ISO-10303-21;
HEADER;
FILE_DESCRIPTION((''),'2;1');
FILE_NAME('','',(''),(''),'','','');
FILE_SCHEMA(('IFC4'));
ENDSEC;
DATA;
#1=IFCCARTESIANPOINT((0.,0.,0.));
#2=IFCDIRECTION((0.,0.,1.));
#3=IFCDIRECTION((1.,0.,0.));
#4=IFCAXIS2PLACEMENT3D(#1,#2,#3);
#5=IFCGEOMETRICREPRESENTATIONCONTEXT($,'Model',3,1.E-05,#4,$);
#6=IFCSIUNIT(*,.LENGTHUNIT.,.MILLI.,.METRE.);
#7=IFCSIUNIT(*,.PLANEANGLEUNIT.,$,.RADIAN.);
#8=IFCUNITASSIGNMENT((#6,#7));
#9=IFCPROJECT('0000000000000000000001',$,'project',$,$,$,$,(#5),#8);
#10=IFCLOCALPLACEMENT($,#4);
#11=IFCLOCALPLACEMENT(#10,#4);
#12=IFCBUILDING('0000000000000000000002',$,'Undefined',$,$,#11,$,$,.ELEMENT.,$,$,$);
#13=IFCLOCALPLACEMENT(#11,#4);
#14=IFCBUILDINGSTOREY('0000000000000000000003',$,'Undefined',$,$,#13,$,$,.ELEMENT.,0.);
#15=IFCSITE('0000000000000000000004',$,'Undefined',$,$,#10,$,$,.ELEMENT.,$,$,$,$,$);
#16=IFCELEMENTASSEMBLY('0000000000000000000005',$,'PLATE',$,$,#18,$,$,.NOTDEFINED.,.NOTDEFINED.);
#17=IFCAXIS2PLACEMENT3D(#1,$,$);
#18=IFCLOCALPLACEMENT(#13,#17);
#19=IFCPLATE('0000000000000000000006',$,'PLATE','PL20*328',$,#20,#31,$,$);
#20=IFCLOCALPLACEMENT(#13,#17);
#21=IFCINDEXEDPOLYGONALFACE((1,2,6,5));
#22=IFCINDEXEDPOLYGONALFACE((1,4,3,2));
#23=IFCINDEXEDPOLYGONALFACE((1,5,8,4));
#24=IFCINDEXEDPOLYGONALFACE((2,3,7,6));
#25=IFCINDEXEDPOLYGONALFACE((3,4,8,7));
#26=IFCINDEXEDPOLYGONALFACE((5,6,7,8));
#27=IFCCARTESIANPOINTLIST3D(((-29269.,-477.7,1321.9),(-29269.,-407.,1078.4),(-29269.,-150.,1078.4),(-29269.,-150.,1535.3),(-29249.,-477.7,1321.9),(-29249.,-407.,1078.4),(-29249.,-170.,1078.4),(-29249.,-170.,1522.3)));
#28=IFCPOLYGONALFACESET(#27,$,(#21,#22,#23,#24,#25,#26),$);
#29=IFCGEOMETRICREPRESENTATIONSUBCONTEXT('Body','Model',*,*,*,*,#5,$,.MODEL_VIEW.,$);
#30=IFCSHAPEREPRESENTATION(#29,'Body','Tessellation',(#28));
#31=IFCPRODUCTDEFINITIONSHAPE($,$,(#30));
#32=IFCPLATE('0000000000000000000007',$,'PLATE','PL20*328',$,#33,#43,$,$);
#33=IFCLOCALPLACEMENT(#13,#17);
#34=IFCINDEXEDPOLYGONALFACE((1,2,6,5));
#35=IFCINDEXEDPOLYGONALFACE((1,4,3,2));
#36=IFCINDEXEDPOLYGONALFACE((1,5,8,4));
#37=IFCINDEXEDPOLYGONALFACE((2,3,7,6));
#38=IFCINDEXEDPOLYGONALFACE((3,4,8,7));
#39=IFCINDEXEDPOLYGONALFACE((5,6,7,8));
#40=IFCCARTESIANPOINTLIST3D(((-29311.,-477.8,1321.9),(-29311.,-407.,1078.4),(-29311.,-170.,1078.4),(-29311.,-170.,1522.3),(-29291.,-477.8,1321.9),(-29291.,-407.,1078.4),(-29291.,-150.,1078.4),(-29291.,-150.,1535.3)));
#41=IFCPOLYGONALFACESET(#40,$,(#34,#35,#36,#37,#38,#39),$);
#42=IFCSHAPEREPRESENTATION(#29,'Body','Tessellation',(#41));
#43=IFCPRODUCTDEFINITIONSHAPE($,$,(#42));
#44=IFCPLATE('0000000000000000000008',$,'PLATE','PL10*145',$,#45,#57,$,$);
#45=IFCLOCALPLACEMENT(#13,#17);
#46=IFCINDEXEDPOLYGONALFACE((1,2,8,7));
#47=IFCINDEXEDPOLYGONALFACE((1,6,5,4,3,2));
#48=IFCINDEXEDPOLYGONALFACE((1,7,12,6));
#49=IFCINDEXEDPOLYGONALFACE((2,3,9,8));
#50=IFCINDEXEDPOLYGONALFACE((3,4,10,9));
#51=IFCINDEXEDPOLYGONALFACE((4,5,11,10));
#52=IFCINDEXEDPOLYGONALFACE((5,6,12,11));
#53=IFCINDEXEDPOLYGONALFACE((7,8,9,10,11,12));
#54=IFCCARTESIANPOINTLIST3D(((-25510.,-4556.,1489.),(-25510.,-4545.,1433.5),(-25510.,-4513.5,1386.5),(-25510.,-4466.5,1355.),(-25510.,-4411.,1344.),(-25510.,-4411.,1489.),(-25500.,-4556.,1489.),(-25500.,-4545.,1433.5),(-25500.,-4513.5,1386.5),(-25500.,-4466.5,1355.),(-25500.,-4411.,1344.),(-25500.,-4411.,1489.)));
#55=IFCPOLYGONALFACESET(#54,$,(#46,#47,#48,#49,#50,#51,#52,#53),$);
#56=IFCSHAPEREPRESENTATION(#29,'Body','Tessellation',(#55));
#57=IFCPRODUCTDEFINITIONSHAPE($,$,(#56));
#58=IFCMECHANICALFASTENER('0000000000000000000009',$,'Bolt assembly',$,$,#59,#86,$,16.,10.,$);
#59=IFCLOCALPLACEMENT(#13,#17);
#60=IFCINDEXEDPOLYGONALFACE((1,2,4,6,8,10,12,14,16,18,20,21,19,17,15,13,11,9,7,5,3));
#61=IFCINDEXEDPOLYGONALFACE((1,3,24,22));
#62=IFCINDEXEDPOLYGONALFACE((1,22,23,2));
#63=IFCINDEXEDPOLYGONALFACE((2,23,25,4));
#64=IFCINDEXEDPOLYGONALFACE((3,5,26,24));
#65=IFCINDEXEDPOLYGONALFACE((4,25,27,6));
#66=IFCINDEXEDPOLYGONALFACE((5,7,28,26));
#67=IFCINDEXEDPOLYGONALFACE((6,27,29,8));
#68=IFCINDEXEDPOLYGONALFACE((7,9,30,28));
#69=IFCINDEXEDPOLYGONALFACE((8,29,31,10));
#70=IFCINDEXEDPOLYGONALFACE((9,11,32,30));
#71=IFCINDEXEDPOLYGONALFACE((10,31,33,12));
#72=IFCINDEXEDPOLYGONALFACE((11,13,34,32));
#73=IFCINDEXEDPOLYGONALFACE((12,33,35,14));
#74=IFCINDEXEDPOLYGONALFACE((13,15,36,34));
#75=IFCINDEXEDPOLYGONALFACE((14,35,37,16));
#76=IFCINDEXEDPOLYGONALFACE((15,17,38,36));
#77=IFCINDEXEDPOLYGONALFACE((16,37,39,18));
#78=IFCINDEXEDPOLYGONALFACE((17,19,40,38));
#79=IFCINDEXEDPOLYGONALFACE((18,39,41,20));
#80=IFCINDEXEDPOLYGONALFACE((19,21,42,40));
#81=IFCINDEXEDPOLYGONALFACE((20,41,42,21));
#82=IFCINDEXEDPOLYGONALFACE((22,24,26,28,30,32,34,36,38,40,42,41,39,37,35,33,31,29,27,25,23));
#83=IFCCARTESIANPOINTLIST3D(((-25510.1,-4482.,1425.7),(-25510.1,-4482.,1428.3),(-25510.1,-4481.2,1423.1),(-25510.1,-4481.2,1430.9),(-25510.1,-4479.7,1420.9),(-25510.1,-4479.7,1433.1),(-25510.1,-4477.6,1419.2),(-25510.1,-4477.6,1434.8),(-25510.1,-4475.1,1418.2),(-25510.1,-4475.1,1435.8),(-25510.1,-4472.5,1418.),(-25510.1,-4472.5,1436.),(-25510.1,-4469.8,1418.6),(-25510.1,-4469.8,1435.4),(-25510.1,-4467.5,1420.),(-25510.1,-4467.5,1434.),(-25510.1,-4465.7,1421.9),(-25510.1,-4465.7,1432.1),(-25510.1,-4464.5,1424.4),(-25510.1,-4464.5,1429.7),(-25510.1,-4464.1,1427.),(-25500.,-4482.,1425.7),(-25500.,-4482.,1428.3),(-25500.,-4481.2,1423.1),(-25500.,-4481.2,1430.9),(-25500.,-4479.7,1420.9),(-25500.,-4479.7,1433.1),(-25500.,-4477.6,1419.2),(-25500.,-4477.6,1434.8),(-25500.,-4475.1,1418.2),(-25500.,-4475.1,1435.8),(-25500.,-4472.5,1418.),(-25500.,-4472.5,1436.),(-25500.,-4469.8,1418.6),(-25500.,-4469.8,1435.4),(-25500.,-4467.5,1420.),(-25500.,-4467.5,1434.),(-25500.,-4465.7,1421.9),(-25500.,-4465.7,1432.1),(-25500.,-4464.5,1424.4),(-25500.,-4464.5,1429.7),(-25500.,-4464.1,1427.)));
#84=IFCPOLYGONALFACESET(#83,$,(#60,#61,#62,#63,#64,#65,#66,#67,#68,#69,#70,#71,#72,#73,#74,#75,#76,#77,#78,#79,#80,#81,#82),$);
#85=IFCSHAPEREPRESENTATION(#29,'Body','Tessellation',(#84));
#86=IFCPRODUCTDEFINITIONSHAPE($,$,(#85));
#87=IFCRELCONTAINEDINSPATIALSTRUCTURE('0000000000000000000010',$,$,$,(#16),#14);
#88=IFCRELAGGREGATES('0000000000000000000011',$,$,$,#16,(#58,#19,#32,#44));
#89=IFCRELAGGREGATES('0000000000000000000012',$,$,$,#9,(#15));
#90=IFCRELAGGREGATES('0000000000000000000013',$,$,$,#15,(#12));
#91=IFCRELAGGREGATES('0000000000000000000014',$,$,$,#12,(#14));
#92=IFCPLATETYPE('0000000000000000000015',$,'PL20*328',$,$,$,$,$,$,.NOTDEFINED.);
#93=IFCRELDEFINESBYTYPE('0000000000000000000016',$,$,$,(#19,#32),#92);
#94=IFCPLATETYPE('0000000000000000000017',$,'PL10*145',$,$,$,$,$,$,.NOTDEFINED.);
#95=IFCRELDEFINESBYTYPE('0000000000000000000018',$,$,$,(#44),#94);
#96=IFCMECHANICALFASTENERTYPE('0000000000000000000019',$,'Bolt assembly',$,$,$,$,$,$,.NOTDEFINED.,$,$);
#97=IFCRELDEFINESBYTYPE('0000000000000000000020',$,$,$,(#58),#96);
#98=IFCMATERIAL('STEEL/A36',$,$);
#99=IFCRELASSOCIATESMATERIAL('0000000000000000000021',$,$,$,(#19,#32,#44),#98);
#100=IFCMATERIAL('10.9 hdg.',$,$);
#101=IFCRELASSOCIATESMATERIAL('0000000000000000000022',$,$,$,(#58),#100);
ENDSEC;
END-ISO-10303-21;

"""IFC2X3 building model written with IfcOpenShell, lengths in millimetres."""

from ifc_helpers import new_model, si_unit, frame, origin_with_axes, origin_2d_with_axis, place, context, subcontext, project, spatial, polyline, circle, outline, extrude, boolean, source, transform, mapped, material, type_object, element, aggregate, save


model = new_model("IFC2X3")

# Units and contexts
model_context = context("Model", 3, precision=1e-05, world=origin_with_axes())
body_context = subcontext(model_context, "Body", "Model", "MODEL_VIEW")
ifc_project = project(units=[si_unit("LENGTHUNIT", "METRE", prefix="MILLI"), si_unit("PLANEANGLEUNIT", "RADIAN")], contexts=[model_context])

# Site, building, storey
site_placement = place(None, origin_with_axes())
site = spatial("IfcSite", under=ifc_project, at=site_placement, Name="Undefined", CompositionType="ELEMENT")
building_placement = place(site_placement, origin_with_axes())
building = spatial("IfcBuilding", under=site, at=building_placement, Name="Undefined", CompositionType="ELEMENT")
storey_placement = place(building_placement, origin_with_axes())
storey = spatial("IfcBuildingStorey", under=building, at=storey_placement, Name="Undefined", CompositionType="ELEMENT", Elevation=0.0)

# Element assembly
assembly_1_placement = place(storey_placement, origin_with_axes())
assembly_1 = element("IfcElementAssembly", 1, at=assembly_1_placement, inside=storey, Name="PLATE", AssemblyPlace="NOTDEFINED", PredefinedType="NOTDEFINED")
ifc_material_1 = material(Name="STEEL/A36")

# Plates
plate_type_1 = type_object("IfcPlateType", Name="PL20*328", PredefinedType="NOTDEFINED")
plate_1_placement = place(assembly_1_placement, frame((-29259.0, -150.0, 1535.3), z_axis=(1.0, 0.0, 0.0), x_axis=(0.0, -0.83796, -0.545732)))
plate_1 = element("IfcPlate", 2, at=plate_1_placement, type_object=plate_type_1, material=ifc_material_1, Name="PLATE", Description="PL20*328", context=body_context, shape_type="CSG", body=[
    boolean("DIFFERENCE", extrude(outline(polyline([(0.0, 0.0), (391.1, 0.0), (464.7, 242.6), (249.4, 382.9), (0.0, 0.0)])), frame((0.0, 0.0, -10.0), z_axis=(0.0, 0.0, 1.0), x_axis=(1.0, 0.0, 0.0)), (0.0, 0.0, 1.0), 20.0), extrude(outline(polyline([(0.0, 0.0), (20.0, 0.0), (20.0, 20.0), (0.0, 0.0)])), frame((-1.4, -2.1, -10.0), z_axis=(0.545732, 0.83796, 0.0), x_axis=(0.0, 0.0, 1.0)), (0.0, 0.0, 1.0), 462.0)),
])
plate_2_placement = place(assembly_1_placement, frame((-29301.0, -150.0, 1535.3), z_axis=(1.0, 0.0, 0.0), x_axis=(0.0, -0.83796, -0.545732)))
plate_2 = element("IfcPlate", 3, at=plate_2_placement, type_object=plate_type_1, material=ifc_material_1, Name="PLATE", Description="PL20*328", context=body_context, shape_type="CSG", body=[
    boolean("DIFFERENCE", extrude(outline(polyline([(0.0, 0.0), (391.1, 0.0), (464.7, 242.6), (249.4, 382.9), (0.0, 0.0)])), frame((0.0, 0.0, -10.0), z_axis=(0.0, 0.0, 1.0), x_axis=(1.0, 0.0, 0.0)), (0.0, 0.0, 1.0), 20.0), extrude(outline(polyline([(0.0, 0.0), (20.0, 0.0), (20.0, 20.0), (0.0, 0.0)])), frame((250.7, 385.0, 10.0), z_axis=(-0.545732, -0.83796, 0.0), x_axis=(0.0, 0.0, -1.0)), (0.0, 0.0, 1.0), 462.0)),
])
plate_type_2 = type_object("IfcPlateType", Name="PL10*145", PredefinedType="NOTDEFINED")
plate_3_placement = place(assembly_1_placement, frame((-25505.0, -4411.0, 1344.0), z_axis=(1.0, 0.0, 0.0), x_axis=(0.0, 0.0, 1.0)))
plate_3 = element("IfcPlate", 4, at=plate_3_placement, type_object=plate_type_2, material=ifc_material_1, Name="PLATE", Description="PL10*145", context=body_context, shape_type="SweptSolid", body=[
    extrude(outline(polyline([(0.0, 0.0), (145.0, 0.0), (145.0, 145.0), (145.0, 145.0), (89.5, 134.0), (42.5, 102.5), (11.0, 55.5), (0.0, 0.0), (0.0, 0.0)])), frame((0.0, 0.0, -5.0), z_axis=(0.0, 0.0, 1.0), x_axis=(1.0, 0.0, 0.0)), (0.0, 0.0, 1.0), 10.0),
])

# Shared definitions
mechanical_fastener_type = type_object("IfcMechanicalFastenerType", Name="Bolt assembly")

# Mechanical fastener
ifc_material_2 = material(Name="10.9 hdg.")
shared_shape_1 = source(origin_with_axes(), body_context, "Body", "SweptSolid", [
    extrude(circle(Radius=9.0, at=origin_2d_with_axis()), frame((0.0, 0.0, 0.0), z_axis=(0.0, 1.0, 0.0), x_axis=(1.0, 0.0, 0.0)), (0.0, 0.0, 1.0), 10.1),
])
mechanical_fastener_1_placement = place(assembly_1_placement, frame((-25500.0, -4473.1, 1427.0), z_axis=(0.0, 0.0, 1.0), x_axis=(0.0, 1.0, 0.0)))
mechanical_fastener_1 = element("IfcMechanicalFastener", 5, at=mechanical_fastener_1_placement, type_object=mechanical_fastener_type, material=ifc_material_2, Name="Bolt assembly", NominalDiameter=16.0, NominalLength=10.0, context=body_context, shape_type="MappedRepresentation", body=[
    mapped(shared_shape_1, transform((0.0, 0.0, 0.0))),
])
aggregate(assembly_1, [mechanical_fastener_1, plate_1, plate_2, plate_3])

save(model, "model.ifc")
